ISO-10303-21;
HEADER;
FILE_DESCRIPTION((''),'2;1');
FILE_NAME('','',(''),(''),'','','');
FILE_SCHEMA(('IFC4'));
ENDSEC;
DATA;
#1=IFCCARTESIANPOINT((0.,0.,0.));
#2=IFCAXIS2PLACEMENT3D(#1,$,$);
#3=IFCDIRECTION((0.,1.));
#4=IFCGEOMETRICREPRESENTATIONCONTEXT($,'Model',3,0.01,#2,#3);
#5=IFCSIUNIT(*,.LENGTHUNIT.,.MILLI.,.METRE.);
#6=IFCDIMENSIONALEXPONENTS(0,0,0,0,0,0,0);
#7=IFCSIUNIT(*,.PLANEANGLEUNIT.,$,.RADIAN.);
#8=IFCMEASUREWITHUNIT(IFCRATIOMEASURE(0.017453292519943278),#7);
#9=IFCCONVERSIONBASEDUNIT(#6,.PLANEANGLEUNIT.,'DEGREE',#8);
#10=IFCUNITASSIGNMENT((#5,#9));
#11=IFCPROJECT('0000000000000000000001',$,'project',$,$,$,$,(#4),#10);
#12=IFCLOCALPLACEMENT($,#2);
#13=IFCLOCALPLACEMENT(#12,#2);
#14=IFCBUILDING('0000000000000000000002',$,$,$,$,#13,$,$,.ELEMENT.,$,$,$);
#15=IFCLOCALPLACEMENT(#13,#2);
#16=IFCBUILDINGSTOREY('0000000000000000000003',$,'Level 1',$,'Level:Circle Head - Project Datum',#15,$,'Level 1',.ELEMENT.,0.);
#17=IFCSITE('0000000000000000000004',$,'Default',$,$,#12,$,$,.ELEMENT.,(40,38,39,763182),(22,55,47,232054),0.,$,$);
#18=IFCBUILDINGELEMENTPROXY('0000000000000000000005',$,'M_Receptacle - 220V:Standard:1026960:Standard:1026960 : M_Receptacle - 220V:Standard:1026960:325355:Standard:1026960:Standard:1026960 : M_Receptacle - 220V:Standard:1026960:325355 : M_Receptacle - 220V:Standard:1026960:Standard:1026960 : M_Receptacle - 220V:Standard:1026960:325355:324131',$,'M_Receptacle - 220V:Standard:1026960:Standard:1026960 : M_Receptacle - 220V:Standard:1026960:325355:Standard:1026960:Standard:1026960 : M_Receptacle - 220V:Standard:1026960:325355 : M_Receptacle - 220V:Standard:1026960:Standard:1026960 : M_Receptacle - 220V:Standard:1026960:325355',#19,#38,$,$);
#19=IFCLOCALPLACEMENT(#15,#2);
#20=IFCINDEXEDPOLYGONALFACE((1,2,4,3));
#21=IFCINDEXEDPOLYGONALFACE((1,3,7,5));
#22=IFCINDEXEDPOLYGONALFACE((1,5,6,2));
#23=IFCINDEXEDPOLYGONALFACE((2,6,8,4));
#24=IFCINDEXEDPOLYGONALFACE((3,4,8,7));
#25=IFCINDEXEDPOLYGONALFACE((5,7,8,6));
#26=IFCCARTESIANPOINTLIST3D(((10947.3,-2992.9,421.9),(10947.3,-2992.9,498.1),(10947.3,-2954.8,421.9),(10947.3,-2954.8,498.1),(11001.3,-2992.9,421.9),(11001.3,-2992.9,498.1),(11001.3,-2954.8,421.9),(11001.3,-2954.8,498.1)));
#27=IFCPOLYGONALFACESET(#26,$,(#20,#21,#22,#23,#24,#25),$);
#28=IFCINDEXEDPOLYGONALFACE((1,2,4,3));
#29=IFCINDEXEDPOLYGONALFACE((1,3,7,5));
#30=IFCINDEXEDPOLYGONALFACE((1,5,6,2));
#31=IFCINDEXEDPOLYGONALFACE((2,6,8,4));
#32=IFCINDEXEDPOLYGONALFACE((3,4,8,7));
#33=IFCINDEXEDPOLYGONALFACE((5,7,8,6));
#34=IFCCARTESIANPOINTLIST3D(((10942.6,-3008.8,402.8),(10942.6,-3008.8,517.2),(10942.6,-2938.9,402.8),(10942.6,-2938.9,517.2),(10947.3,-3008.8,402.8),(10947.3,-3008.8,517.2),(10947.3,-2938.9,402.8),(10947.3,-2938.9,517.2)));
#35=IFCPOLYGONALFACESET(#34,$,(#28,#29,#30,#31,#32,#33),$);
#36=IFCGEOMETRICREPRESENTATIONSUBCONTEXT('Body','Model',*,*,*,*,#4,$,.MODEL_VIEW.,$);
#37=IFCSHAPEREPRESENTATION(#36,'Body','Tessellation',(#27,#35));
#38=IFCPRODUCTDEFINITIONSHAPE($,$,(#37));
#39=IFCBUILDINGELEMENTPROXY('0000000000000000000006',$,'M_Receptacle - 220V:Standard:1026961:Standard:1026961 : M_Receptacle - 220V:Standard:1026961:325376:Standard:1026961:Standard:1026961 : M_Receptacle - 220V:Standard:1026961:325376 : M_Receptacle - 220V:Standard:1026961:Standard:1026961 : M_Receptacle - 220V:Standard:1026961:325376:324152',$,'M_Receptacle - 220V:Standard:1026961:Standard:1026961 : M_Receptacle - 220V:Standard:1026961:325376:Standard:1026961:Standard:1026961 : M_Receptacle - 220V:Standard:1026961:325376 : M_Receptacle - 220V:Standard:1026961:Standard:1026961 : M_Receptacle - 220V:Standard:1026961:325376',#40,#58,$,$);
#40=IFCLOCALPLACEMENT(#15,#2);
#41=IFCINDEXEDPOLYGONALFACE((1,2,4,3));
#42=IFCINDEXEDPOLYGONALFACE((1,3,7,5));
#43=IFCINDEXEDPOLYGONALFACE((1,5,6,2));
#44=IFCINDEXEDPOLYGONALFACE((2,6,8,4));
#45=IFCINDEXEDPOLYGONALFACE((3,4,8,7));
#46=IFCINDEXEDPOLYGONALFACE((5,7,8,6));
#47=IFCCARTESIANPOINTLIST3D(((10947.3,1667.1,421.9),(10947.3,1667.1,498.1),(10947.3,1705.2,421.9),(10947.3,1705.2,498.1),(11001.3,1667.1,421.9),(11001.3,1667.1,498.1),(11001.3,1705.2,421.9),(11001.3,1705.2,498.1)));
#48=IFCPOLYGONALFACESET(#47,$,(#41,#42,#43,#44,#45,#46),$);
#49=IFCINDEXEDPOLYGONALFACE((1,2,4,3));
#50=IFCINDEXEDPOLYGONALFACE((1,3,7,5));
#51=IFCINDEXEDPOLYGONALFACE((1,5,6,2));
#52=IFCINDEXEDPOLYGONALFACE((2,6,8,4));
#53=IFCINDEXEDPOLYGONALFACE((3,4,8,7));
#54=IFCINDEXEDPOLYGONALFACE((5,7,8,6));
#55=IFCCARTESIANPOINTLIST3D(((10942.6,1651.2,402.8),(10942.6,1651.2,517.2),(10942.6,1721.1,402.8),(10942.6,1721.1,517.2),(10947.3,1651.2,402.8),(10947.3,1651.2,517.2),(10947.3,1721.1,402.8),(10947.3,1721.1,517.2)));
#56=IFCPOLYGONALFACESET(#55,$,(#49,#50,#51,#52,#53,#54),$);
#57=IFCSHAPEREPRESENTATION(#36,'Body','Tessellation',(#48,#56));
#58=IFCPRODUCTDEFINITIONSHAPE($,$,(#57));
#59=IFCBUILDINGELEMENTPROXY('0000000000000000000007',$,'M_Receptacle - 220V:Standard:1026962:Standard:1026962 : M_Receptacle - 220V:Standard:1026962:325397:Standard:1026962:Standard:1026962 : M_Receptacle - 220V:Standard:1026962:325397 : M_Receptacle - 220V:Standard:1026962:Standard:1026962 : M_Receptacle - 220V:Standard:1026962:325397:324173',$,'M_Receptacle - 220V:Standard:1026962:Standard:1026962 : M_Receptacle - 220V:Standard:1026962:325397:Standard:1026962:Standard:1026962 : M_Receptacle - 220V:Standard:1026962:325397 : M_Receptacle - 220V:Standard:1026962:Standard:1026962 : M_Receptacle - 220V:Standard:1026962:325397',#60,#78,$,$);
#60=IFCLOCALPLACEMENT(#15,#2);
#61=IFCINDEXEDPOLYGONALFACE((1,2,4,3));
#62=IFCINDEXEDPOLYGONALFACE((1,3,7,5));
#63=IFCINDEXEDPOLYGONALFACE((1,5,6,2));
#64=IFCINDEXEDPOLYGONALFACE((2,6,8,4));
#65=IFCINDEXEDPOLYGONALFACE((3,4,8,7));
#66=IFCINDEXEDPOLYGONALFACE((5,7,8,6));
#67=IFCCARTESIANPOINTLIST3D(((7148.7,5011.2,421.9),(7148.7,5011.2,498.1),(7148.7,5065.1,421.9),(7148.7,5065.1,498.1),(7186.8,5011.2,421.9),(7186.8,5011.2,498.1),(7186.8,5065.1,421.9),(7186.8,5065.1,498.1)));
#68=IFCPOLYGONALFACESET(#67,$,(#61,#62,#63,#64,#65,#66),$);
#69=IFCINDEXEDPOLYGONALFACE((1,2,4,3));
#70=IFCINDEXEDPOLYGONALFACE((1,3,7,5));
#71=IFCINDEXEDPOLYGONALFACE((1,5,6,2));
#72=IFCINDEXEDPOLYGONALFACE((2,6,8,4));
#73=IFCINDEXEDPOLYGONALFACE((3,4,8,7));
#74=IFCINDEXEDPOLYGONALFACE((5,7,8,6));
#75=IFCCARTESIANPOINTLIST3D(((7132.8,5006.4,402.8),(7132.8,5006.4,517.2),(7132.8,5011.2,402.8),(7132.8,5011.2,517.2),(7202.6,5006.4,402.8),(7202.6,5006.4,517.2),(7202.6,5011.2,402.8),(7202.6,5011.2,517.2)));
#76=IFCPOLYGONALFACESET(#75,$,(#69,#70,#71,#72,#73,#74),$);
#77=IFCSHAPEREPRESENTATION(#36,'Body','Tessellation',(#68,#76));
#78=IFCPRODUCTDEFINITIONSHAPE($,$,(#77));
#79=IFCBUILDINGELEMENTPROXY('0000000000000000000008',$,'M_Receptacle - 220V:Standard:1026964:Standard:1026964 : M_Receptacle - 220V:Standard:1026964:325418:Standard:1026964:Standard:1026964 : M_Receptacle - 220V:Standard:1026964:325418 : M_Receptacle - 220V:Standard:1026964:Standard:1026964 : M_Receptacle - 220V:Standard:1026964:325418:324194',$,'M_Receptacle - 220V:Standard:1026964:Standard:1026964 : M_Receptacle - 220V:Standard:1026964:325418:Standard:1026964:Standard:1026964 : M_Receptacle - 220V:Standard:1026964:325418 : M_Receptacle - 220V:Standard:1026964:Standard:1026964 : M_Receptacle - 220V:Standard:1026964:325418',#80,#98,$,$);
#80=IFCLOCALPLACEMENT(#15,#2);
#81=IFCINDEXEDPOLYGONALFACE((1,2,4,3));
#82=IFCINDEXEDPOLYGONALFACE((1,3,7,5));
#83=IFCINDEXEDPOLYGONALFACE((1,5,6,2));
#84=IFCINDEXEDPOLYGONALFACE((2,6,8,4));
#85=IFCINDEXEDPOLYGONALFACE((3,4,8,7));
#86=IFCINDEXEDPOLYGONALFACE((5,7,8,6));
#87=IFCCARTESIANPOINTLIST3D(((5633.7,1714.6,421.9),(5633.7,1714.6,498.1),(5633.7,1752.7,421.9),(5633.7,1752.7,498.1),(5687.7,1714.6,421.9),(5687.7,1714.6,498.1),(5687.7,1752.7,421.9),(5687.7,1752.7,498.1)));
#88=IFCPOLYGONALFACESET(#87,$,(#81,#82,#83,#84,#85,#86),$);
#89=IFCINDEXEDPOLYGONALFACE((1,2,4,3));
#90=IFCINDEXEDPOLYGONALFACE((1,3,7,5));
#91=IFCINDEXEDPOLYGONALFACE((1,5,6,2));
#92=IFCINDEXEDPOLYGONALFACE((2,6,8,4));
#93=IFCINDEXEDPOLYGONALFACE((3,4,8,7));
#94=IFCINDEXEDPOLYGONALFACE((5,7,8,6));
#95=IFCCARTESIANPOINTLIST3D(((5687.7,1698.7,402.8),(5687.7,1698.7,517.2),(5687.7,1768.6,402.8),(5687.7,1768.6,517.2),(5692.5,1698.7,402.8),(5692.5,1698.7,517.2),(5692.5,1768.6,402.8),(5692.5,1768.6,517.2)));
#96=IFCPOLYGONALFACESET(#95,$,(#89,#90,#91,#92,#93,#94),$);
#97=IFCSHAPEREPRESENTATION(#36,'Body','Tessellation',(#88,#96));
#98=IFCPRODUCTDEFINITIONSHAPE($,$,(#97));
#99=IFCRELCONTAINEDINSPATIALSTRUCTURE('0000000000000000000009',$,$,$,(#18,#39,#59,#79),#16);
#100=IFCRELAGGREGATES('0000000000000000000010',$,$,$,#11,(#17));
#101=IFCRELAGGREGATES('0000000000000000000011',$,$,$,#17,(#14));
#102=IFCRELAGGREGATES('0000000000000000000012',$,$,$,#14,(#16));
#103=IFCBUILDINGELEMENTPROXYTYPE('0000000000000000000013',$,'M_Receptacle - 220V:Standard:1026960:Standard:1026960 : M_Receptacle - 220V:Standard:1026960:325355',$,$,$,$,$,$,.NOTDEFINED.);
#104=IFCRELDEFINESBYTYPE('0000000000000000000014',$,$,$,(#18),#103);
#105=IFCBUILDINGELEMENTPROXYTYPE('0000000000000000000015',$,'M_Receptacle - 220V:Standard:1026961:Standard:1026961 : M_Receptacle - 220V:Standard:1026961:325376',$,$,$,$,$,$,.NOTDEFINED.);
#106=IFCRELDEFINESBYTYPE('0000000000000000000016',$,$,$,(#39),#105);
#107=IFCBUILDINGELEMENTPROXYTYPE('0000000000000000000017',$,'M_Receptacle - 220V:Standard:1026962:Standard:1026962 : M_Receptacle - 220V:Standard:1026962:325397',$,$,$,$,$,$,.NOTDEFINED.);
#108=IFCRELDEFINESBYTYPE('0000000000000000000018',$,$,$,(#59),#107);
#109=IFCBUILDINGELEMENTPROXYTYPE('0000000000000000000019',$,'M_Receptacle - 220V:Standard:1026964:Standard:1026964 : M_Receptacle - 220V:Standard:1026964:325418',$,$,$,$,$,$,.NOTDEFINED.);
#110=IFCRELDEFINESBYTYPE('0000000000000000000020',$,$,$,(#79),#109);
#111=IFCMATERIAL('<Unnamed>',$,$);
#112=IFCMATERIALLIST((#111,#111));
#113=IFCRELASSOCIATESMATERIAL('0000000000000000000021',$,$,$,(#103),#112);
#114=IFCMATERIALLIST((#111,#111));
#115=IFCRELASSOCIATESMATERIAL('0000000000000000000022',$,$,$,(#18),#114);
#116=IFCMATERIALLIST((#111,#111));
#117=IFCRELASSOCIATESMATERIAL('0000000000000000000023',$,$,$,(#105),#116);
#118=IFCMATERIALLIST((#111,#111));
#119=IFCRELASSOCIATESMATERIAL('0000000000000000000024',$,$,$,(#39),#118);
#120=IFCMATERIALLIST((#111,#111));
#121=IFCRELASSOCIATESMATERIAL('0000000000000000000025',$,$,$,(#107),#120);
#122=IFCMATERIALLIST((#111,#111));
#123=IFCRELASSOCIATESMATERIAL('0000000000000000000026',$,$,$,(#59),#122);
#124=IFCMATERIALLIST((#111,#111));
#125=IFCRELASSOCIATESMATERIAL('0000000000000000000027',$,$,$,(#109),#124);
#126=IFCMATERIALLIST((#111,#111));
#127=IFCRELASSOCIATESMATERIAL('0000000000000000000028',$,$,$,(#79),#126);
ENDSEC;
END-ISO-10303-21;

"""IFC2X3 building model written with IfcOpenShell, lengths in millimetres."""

from ifc_helpers import new_model, entity, si_unit, converted_unit, direction, frame, frame_2d, origin, origin_2d_with_axis, place, context, subcontext, project, spatial, rectangle, extrude, source, transform, mapped, material, material_list, type_object, type_shapes, element, save


model = new_model("IFC2X3")

# Units and contexts
model_context = context("Model", 3, precision=0.01, world=origin(), true_north=direction((0.0, 1.0)))
body_context = subcontext(model_context, "Body", "Model", "MODEL_VIEW")
ifc_project = project(units=[si_unit("LENGTHUNIT", "METRE", prefix="MILLI"), converted_unit("PLANEANGLEUNIT", "DEGREE", entity("IfcRatioMeasure", 0.017453292519943278), si_unit("PLANEANGLEUNIT", "RADIAN"), dimensions=[0, 0, 0, 0, 0, 0, 0])], contexts=[model_context])

# Site, building, storey
site_placement = place(None, origin())
site = spatial("IfcSite", under=ifc_project, at=site_placement, Name="Default", CompositionType="ELEMENT", RefLatitude=(40, 38, 39, 763182), RefLongitude=(22, 55, 47, 232054), RefElevation=0.0)
building_placement = place(site_placement, origin())
building = spatial("IfcBuilding", under=site, at=building_placement, CompositionType="ELEMENT")
storey_placement = place(building_placement, origin())
storey = spatial("IfcBuildingStorey", under=building, at=storey_placement, Name="Level 1", ObjectType="Level:Circle Head - Project Datum", LongName="Level 1", CompositionType="ELEMENT", Elevation=0.0)

# Shared definitions
ifc_material = material(Name="<Unnamed>")

# Building element proxies
ifc_material_list_1 = material_list([ifc_material, ifc_material])
ifc_material_list_2 = material_list([ifc_material, ifc_material])
building_element_proxy_type_1 = type_object("IfcBuildingElementProxyType", Name="M_Receptacle - 220V:Standard:1026960:Standard:1026960 : M_Receptacle - 220V:Standard:1026960:325355", PredefinedType="NOTDEFINED", material=ifc_material_list_2)
shared_shape_1 = source(origin(), body_context, "Body", "SweptSolid", [
    extrude(rectangle(XDim=38.1, YDim=54.0, at=frame_2d((0.0, 0.0), x_axis=(1.0, 0.0))), frame((10974.3, -2973.8, 421.9), z_axis=(0.0, 0.0, 1.0), x_axis=(0.0, 1.0, 0.0)), (0.0, 0.0, 1.0), 76.2),
    extrude(rectangle(XDim=69.8, YDim=4.8, at=frame_2d((0.0, 0.0), x_axis=(1.0, 0.0))), frame((10945.0, -2973.8, 402.8), z_axis=(0.0, 0.0, 1.0), x_axis=(0.0, 1.0, 0.0)), (0.0, 0.0, 1.0), 114.3),
])
type_shapes(building_element_proxy_type_1, [shared_shape_1])
proxy_1_placement = place(storey_placement, origin())
element("IfcBuildingElementProxy", 1, at=proxy_1_placement, inside=storey, type_object=building_element_proxy_type_1, material=ifc_material_list_1, Name="M_Receptacle - 220V:Standard:1026960:Standard:1026960 : M_Receptacle - 220V:Standard:1026960:325355:Standard:1026960:Standard:1026960 : M_Receptacle - 220V:Standard:1026960:325355 : M_Receptacle - 220V:Standard:1026960:Standard:1026960 : M_Receptacle - 220V:Standard:1026960:325355:324131", ObjectType="M_Receptacle - 220V:Standard:1026960:Standard:1026960 : M_Receptacle - 220V:Standard:1026960:325355:Standard:1026960:Standard:1026960 : M_Receptacle - 220V:Standard:1026960:325355 : M_Receptacle - 220V:Standard:1026960:Standard:1026960 : M_Receptacle - 220V:Standard:1026960:325355", context=body_context, shape_type="MappedRepresentation", body=[
    mapped(shared_shape_1, transform((0.0, 0.0, 0.0), scale=1.0)),
])
ifc_material_list_3 = material_list([ifc_material, ifc_material])
ifc_material_list_4 = material_list([ifc_material, ifc_material])
building_element_proxy_type_2 = type_object("IfcBuildingElementProxyType", Name="M_Receptacle - 220V:Standard:1026961:Standard:1026961 : M_Receptacle - 220V:Standard:1026961:325376", PredefinedType="NOTDEFINED", material=ifc_material_list_4)
shared_shape_2 = source(origin(), body_context, "Body", "SweptSolid", [
    extrude(rectangle(XDim=38.1, YDim=54.0, at=frame_2d((0.0, 0.0), x_axis=(1.0, 0.0))), frame((10974.3, 1686.2, 421.9), z_axis=(0.0, 0.0, 1.0), x_axis=(0.0, 1.0, 0.0)), (0.0, 0.0, 1.0), 76.2),
    extrude(rectangle(XDim=69.8, YDim=4.8, at=frame_2d((0.0, 0.0), x_axis=(1.0, 0.0))), frame((10945.0, 1686.2, 402.8), z_axis=(0.0, 0.0, 1.0), x_axis=(0.0, 1.0, 0.0)), (0.0, 0.0, 1.0), 114.3),
])
type_shapes(building_element_proxy_type_2, [shared_shape_2])
proxy_2_placement = place(storey_placement, origin())
element("IfcBuildingElementProxy", 2, at=proxy_2_placement, inside=storey, type_object=building_element_proxy_type_2, material=ifc_material_list_3, Name="M_Receptacle - 220V:Standard:1026961:Standard:1026961 : M_Receptacle - 220V:Standard:1026961:325376:Standard:1026961:Standard:1026961 : M_Receptacle - 220V:Standard:1026961:325376 : M_Receptacle - 220V:Standard:1026961:Standard:1026961 : M_Receptacle - 220V:Standard:1026961:325376:324152", ObjectType="M_Receptacle - 220V:Standard:1026961:Standard:1026961 : M_Receptacle - 220V:Standard:1026961:325376:Standard:1026961:Standard:1026961 : M_Receptacle - 220V:Standard:1026961:325376 : M_Receptacle - 220V:Standard:1026961:Standard:1026961 : M_Receptacle - 220V:Standard:1026961:325376", context=body_context, shape_type="MappedRepresentation", body=[
    mapped(shared_shape_2, transform((0.0, 0.0, 0.0), scale=1.0)),
])
ifc_material_list_5 = material_list([ifc_material, ifc_material])
ifc_material_list_6 = material_list([ifc_material, ifc_material])
building_element_proxy_type_3 = type_object("IfcBuildingElementProxyType", Name="M_Receptacle - 220V:Standard:1026962:Standard:1026962 : M_Receptacle - 220V:Standard:1026962:325397", PredefinedType="NOTDEFINED", material=ifc_material_list_6)
shared_shape_3 = source(origin(), body_context, "Body", "SweptSolid", [
    extrude(rectangle(XDim=38.1, YDim=54.0, at=origin_2d_with_axis()), frame((7167.7, 5038.1, 421.9), z_axis=(0.0, 0.0, 1.0), x_axis=(-1.0, 0.0, 0.0)), (0.0, 0.0, 1.0), 76.2),
    extrude(rectangle(XDim=69.8, YDim=4.8, at=frame_2d((0.0, 0.0), x_axis=(1.0, 0.0))), frame((7167.7, 5008.8, 402.8), z_axis=(0.0, 0.0, 1.0), x_axis=(-1.0, 0.0, 0.0)), (0.0, 0.0, 1.0), 114.3),
])
type_shapes(building_element_proxy_type_3, [shared_shape_3])
proxy_3_placement = place(storey_placement, origin())
element("IfcBuildingElementProxy", 3, at=proxy_3_placement, inside=storey, type_object=building_element_proxy_type_3, material=ifc_material_list_5, Name="M_Receptacle - 220V:Standard:1026962:Standard:1026962 : M_Receptacle - 220V:Standard:1026962:325397:Standard:1026962:Standard:1026962 : M_Receptacle - 220V:Standard:1026962:325397 : M_Receptacle - 220V:Standard:1026962:Standard:1026962 : M_Receptacle - 220V:Standard:1026962:325397:324173", ObjectType="M_Receptacle - 220V:Standard:1026962:Standard:1026962 : M_Receptacle - 220V:Standard:1026962:325397:Standard:1026962:Standard:1026962 : M_Receptacle - 220V:Standard:1026962:325397 : M_Receptacle - 220V:Standard:1026962:Standard:1026962 : M_Receptacle - 220V:Standard:1026962:325397", context=body_context, shape_type="MappedRepresentation", body=[
    mapped(shared_shape_3, transform((0.0, 0.0, 0.0), scale=1.0)),
])
ifc_material_list_7 = material_list([ifc_material, ifc_material])
ifc_material_list_8 = material_list([ifc_material, ifc_material])
building_element_proxy_type_4 = type_object("IfcBuildingElementProxyType", Name="M_Receptacle - 220V:Standard:1026964:Standard:1026964 : M_Receptacle - 220V:Standard:1026964:325418", PredefinedType="NOTDEFINED", material=ifc_material_list_8)
shared_shape_4 = source(origin(), body_context, "Body", "SweptSolid", [
    extrude(rectangle(XDim=38.1, YDim=54.0, at=frame_2d((0.0, 0.0), x_axis=(1.0, 0.0))), frame((5660.7, 1733.7, 421.9), z_axis=(0.0, 0.0, 1.0), x_axis=(0.0, -1.0, 0.0)), (0.0, 0.0, 1.0), 76.2),
    extrude(rectangle(XDim=69.8, YDim=4.8, at=origin_2d_with_axis()), frame((5690.1, 1733.7, 402.8), z_axis=(0.0, 0.0, 1.0), x_axis=(0.0, -1.0, 0.0)), (0.0, 0.0, 1.0), 114.3),
])
type_shapes(building_element_proxy_type_4, [shared_shape_4])
proxy_4_placement = place(storey_placement, origin())
element("IfcBuildingElementProxy", 4, at=proxy_4_placement, inside=storey, type_object=building_element_proxy_type_4, material=ifc_material_list_7, Name="M_Receptacle - 220V:Standard:1026964:Standard:1026964 : M_Receptacle - 220V:Standard:1026964:325418:Standard:1026964:Standard:1026964 : M_Receptacle - 220V:Standard:1026964:325418 : M_Receptacle - 220V:Standard:1026964:Standard:1026964 : M_Receptacle - 220V:Standard:1026964:325418:324194", ObjectType="M_Receptacle - 220V:Standard:1026964:Standard:1026964 : M_Receptacle - 220V:Standard:1026964:325418:Standard:1026964:Standard:1026964 : M_Receptacle - 220V:Standard:1026964:325418 : M_Receptacle - 220V:Standard:1026964:Standard:1026964 : M_Receptacle - 220V:Standard:1026964:325418", context=body_context, shape_type="MappedRepresentation", body=[
    mapped(shared_shape_4, transform((0.0, 0.0, 0.0), scale=1.0)),
])

save(model, "model.ifc")
